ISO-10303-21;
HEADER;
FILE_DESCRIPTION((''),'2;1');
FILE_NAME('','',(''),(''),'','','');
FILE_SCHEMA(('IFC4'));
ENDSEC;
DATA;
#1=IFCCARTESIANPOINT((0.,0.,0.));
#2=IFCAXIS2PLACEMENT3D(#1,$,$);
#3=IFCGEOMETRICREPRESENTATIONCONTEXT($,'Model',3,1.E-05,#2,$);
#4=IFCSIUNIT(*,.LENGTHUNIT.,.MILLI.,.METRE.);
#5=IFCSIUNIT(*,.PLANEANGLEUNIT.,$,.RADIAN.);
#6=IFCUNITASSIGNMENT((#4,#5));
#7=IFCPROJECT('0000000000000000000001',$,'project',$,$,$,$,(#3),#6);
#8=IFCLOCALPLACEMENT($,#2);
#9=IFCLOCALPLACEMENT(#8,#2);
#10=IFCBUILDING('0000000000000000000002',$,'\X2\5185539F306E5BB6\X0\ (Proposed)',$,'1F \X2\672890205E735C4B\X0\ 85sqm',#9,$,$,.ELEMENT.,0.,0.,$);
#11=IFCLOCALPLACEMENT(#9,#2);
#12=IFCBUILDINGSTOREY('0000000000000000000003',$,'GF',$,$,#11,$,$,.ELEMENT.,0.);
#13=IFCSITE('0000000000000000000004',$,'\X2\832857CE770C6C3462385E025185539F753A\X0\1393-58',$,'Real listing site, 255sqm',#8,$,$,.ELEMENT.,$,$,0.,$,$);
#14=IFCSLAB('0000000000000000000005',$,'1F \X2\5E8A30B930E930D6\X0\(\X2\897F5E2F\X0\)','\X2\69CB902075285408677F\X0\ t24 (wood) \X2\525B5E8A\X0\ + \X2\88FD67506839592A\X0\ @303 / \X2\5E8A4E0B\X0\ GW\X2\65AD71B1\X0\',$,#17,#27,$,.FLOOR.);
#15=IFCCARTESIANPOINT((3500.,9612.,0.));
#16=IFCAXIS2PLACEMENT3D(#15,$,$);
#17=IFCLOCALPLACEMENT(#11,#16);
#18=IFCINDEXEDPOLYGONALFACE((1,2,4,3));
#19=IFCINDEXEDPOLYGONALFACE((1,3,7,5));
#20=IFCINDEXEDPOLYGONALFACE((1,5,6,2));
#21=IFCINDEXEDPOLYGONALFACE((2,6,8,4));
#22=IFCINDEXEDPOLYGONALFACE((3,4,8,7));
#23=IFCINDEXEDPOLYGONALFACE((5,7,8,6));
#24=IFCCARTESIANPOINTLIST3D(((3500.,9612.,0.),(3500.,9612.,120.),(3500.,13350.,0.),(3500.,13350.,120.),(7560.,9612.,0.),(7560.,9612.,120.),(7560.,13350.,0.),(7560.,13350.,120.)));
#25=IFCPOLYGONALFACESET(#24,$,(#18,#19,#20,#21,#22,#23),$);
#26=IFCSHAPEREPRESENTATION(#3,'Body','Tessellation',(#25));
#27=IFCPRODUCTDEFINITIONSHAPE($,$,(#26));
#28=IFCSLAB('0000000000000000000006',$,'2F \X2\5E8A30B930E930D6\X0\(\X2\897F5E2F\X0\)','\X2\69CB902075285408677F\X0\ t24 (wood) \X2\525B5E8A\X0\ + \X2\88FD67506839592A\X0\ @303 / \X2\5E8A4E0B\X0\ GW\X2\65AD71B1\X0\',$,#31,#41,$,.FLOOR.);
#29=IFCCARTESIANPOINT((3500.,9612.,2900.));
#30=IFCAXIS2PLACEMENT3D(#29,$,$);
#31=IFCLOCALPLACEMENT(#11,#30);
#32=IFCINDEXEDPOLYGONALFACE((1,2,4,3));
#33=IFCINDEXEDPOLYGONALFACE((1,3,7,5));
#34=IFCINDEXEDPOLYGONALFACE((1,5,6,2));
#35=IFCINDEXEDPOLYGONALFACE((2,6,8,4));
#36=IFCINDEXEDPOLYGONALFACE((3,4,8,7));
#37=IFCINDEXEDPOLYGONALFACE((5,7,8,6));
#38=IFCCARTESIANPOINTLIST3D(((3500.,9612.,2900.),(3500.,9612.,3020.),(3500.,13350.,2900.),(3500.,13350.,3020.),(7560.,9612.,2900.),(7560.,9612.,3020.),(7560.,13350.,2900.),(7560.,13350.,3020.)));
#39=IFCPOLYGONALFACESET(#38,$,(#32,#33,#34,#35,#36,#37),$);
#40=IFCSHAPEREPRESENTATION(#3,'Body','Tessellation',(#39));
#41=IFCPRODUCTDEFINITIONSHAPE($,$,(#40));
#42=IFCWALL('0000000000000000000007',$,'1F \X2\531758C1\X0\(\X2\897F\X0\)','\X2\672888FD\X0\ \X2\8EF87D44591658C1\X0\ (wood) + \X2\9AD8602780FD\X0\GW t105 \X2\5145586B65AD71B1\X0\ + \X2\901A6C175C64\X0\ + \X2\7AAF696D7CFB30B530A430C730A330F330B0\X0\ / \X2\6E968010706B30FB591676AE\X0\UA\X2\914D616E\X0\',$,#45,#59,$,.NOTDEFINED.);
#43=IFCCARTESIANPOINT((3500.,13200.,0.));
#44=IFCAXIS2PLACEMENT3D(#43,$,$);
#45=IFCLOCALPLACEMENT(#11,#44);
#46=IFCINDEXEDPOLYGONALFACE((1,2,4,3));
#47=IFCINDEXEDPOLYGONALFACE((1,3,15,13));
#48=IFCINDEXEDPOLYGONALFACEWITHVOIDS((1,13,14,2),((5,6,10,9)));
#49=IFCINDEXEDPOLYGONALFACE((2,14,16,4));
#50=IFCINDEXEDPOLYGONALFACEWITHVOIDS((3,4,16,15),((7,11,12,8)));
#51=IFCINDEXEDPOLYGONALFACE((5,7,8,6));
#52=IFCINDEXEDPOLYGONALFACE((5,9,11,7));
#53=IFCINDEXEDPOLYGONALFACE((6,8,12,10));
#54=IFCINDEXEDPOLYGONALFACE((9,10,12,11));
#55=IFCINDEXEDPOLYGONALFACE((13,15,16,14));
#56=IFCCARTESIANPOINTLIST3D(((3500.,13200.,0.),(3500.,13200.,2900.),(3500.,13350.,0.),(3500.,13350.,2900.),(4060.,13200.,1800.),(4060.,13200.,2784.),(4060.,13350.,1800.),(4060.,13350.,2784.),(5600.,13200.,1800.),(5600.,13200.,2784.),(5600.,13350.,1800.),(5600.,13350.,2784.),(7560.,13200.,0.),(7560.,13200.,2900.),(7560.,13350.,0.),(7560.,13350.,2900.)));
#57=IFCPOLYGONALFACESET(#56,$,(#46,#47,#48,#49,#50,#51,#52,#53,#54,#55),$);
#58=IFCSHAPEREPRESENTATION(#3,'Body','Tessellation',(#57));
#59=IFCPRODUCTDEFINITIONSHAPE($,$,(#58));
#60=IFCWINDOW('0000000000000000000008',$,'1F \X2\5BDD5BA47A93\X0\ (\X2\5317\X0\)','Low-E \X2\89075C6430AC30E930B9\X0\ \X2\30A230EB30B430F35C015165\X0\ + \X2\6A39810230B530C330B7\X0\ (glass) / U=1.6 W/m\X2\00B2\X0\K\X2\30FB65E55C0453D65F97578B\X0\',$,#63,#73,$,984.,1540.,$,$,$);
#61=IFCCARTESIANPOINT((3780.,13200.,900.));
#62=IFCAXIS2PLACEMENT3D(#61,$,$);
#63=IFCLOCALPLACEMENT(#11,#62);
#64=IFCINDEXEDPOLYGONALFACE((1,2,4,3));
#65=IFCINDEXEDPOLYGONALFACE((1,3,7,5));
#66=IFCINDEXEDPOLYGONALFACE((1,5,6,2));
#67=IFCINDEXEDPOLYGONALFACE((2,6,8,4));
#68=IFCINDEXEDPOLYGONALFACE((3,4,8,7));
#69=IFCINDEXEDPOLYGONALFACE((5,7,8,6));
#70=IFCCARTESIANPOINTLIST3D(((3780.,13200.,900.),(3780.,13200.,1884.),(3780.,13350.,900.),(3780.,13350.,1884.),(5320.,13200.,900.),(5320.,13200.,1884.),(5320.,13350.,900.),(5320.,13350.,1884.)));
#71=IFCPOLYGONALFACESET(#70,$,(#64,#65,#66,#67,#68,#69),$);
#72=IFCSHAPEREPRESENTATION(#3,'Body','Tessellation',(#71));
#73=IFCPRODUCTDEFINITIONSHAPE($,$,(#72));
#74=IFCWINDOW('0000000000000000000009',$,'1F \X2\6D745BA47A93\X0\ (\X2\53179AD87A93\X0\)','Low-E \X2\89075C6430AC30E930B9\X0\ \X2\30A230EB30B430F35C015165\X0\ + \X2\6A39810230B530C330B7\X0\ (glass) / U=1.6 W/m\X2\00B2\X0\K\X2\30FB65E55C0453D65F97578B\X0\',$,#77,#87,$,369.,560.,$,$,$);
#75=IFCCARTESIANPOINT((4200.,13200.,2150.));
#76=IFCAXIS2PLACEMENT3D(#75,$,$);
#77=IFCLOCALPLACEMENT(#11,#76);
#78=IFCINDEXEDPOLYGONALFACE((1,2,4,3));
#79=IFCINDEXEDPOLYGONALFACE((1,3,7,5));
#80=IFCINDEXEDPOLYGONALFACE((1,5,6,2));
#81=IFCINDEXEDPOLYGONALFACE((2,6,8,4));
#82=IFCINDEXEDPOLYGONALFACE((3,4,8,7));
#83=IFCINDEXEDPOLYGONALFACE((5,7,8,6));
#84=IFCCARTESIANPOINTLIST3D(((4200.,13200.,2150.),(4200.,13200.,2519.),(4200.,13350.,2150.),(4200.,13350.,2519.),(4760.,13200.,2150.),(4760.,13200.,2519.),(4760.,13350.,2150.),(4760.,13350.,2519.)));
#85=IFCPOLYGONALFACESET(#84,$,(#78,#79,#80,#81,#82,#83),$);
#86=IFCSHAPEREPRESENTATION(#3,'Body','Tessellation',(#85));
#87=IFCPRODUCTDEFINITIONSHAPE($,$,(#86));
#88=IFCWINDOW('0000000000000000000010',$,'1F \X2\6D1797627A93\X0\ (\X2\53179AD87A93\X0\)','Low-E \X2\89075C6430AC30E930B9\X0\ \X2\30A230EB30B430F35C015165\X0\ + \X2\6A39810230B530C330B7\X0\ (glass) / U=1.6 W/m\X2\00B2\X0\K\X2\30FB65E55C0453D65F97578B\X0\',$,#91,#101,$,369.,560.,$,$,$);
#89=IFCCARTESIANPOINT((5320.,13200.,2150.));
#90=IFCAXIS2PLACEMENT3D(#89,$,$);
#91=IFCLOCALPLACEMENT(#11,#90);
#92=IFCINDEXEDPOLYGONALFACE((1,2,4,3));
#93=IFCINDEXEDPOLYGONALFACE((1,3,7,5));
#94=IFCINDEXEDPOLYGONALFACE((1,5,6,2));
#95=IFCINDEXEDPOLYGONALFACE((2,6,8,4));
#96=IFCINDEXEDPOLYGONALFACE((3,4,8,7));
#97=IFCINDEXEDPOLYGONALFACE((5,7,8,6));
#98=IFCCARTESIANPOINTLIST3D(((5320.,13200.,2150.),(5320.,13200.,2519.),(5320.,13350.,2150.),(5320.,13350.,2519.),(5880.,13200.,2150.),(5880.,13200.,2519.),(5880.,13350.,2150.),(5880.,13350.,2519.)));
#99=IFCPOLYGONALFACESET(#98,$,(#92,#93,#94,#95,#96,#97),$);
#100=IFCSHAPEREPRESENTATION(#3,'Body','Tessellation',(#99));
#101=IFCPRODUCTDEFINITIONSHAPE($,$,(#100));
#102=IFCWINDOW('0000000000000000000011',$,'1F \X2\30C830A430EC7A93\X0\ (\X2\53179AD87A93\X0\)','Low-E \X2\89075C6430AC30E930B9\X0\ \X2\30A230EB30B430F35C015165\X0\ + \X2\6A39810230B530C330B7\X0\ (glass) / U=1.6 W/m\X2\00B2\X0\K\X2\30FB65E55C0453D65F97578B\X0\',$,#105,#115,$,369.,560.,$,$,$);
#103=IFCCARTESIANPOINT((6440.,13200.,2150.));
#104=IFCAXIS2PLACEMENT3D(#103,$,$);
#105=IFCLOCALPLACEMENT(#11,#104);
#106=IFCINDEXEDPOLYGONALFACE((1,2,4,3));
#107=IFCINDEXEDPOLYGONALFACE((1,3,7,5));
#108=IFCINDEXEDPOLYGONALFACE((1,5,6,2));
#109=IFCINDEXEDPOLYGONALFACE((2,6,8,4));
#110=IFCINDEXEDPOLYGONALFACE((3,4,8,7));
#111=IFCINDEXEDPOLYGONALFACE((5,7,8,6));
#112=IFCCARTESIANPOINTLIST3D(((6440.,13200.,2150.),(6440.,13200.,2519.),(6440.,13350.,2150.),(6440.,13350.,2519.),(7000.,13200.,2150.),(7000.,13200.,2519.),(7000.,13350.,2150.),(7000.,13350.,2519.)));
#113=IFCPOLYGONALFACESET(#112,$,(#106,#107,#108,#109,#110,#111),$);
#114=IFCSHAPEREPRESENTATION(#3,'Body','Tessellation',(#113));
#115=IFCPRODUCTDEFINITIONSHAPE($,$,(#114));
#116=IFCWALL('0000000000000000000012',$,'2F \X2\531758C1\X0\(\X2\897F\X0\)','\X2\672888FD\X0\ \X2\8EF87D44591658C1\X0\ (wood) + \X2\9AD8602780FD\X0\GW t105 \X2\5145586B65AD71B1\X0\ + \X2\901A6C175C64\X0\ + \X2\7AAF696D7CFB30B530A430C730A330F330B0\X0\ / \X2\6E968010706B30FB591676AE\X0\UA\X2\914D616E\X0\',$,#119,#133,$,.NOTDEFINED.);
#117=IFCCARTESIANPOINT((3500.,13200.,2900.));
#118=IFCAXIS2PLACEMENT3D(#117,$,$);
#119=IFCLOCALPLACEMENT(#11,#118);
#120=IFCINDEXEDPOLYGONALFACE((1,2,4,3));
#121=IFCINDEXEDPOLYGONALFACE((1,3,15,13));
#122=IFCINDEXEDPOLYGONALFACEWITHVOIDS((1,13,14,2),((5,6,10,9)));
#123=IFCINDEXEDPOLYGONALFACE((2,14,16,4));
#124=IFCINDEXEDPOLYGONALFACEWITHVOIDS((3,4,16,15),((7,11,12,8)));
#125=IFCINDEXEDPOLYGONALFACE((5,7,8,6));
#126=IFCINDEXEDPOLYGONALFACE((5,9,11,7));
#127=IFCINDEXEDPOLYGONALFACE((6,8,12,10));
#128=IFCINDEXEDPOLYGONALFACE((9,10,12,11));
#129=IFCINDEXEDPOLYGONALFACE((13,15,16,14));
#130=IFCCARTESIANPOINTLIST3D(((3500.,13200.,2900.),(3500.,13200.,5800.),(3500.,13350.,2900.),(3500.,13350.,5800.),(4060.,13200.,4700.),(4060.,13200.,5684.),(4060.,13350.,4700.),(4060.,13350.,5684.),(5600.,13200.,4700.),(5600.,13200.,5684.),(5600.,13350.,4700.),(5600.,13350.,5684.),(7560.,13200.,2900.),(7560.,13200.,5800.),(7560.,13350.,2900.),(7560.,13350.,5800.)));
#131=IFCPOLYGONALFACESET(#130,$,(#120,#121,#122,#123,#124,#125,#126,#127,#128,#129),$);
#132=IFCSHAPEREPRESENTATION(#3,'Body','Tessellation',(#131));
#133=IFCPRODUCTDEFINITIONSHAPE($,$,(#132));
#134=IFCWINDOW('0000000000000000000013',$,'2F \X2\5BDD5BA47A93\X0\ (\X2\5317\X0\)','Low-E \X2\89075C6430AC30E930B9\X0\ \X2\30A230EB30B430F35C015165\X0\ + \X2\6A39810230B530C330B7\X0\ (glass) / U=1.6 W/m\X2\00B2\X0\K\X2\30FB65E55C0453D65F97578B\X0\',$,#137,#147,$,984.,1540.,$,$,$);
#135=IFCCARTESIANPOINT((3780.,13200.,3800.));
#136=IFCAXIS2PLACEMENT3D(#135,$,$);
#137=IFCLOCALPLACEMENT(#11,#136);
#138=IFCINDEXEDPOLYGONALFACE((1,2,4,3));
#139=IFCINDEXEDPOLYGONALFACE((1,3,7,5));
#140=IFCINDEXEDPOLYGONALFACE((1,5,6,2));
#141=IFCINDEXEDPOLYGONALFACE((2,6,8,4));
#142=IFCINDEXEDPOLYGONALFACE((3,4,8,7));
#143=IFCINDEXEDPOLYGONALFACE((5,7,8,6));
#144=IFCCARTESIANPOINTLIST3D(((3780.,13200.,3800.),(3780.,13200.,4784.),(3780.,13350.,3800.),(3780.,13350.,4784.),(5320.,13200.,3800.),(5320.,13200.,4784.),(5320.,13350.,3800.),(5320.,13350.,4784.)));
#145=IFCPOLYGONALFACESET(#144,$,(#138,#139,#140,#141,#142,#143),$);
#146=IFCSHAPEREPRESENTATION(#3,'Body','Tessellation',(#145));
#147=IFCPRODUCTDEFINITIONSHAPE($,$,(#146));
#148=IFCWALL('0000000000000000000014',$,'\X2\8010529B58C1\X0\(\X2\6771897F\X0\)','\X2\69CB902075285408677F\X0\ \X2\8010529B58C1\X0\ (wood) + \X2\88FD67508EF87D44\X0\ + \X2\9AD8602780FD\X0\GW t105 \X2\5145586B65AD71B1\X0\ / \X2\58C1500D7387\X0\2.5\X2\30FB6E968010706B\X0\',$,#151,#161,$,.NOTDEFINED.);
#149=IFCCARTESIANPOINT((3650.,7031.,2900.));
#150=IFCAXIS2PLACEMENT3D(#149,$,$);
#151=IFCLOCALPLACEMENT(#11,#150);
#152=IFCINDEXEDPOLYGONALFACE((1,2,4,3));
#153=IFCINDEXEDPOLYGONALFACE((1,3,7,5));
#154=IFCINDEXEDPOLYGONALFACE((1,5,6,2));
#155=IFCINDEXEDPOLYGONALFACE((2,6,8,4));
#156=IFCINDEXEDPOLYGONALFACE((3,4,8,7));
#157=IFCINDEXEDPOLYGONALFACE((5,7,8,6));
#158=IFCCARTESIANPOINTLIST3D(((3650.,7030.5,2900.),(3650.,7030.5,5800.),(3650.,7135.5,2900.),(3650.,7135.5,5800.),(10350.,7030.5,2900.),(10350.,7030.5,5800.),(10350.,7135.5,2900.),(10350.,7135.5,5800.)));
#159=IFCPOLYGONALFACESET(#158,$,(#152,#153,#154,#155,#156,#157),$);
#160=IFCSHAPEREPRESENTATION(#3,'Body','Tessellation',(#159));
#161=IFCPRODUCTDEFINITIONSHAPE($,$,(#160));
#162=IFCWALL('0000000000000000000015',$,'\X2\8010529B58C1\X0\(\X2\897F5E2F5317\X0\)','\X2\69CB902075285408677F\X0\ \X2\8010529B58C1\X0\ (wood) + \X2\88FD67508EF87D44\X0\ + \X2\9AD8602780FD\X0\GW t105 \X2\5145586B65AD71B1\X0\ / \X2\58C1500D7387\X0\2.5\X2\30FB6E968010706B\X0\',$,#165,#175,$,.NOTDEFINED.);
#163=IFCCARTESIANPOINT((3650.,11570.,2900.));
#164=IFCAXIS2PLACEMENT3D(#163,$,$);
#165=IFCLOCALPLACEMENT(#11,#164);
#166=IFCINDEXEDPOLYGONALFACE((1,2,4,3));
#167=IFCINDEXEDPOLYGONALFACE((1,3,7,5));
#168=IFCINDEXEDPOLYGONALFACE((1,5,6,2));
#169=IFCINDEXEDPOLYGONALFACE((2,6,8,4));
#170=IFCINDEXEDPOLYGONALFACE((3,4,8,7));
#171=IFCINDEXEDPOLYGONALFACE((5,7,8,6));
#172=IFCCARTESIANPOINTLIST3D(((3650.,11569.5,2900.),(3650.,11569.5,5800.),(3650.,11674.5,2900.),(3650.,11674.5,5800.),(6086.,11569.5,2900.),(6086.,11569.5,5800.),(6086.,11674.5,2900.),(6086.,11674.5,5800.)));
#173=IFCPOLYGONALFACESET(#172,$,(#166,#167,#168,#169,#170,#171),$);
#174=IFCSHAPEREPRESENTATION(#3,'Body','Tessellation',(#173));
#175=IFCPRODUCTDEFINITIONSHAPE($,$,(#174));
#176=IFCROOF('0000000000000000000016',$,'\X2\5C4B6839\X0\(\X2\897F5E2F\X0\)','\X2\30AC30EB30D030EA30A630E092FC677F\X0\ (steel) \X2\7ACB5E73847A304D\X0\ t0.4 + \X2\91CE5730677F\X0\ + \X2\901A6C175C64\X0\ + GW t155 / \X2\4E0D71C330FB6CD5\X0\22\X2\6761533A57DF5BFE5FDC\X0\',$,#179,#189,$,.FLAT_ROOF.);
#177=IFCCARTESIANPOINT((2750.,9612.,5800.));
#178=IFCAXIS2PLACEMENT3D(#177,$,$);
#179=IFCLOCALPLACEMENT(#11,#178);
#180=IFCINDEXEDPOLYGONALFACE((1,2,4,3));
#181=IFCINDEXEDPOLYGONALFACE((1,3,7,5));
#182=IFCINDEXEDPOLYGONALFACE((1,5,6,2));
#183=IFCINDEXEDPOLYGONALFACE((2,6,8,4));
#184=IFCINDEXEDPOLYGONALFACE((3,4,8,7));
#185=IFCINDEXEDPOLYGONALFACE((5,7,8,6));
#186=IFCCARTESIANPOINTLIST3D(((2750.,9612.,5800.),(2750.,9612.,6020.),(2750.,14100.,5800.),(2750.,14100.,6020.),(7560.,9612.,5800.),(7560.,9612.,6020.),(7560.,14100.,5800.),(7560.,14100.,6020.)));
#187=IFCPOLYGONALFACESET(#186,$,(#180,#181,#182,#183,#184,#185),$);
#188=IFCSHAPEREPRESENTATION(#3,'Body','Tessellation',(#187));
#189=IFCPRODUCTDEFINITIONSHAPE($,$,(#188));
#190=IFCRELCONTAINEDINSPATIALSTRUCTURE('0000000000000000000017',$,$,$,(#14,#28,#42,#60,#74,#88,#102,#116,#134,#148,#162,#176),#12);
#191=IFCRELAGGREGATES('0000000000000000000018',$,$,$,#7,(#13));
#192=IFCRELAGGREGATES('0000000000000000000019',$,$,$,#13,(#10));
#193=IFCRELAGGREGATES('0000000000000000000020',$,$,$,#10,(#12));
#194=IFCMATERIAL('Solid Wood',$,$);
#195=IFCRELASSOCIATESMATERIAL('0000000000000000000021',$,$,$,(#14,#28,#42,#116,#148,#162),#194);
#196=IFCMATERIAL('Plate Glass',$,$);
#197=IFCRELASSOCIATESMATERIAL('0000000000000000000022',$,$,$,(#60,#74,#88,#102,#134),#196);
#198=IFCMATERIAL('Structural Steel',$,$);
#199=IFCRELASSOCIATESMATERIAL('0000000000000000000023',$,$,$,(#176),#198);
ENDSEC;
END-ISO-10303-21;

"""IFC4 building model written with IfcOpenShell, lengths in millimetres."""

from ifc_helpers import new_model, si_unit, frame, frame_2d, origin, place, context, project, spatial, rectangle, extrude, material, element, fill, save


model = new_model("IFC4")

# Units and contexts
model_context = context("Model", 3, precision=1e-05, world=origin())
ifc_project = project(units=[si_unit("LENGTHUNIT", "METRE", prefix="MILLI"), si_unit("PLANEANGLEUNIT", "RADIAN")], contexts=[model_context])

# Site, building, storey
site_placement = place(None, origin())
site = spatial("IfcSite", under=ifc_project, at=site_placement, Name="茨城県水戸市内原町1393-58", ObjectType="Real listing site, 255sqm", CompositionType="ELEMENT", RefElevation=0.0)
building_placement = place(site_placement, origin())
building = spatial("IfcBuilding", under=site, at=building_placement, Name="内原の家 (Proposed)", ObjectType="1F 木造平屋 85sqm", CompositionType="ELEMENT", ElevationOfRefHeight=0.0, ElevationOfTerrain=0.0)
storey_placement = place(building_placement, origin())
storey = spatial("IfcBuildingStorey", under=building, at=storey_placement, Name="GF", CompositionType="ELEMENT", Elevation=0.0)

# Slabs
ifc_material_1 = material(Name="Solid Wood")
slab_1_placement = place(storey_placement, frame((3500.0, 9612.0, 0.0)))
element("IfcSlab", 1, at=slab_1_placement, inside=storey, material=ifc_material_1, Name="1F 床スラブ(西帯)", Description="構造用合板 t24 (wood) 剛床 + 製材根太 @303 / 床下 GW断熱", PredefinedType="FLOOR", context=model_context, shape_type="SweptSolid", body=[
    extrude(rectangle(XDim=4060.0, YDim=3738.0, at=frame_2d((2030.0, 1869.0))), frame((3500.0, 9612.0, 0.0)), (0.0, 0.0, 1.0), 120.0),
])
slab_2_placement = place(storey_placement, frame((3500.0, 9612.0, 2900.0)))
element("IfcSlab", 2, at=slab_2_placement, inside=storey, material=ifc_material_1, Name="2F 床スラブ(西帯)", Description="構造用合板 t24 (wood) 剛床 + 製材根太 @303 / 床下 GW断熱", PredefinedType="FLOOR", context=model_context, shape_type="SweptSolid", body=[
    extrude(rectangle(XDim=4060.0, YDim=3738.0, at=frame_2d((2030.0, 1869.0))), frame((3500.0, 9612.0, 2900.0)), (0.0, 0.0, 1.0), 120.0),
])

# Wall, openings, windows
wall_1_placement = place(storey_placement, frame((3500.0, 13200.0, 0.0)))
wall_1 = element("IfcWall", 3, at=wall_1_placement, inside=storey, material=ifc_material_1, Name="1F 北壁(西)", Description="木製 軸組外壁 (wood) + 高性能GW t105 充填断熱 + 通気層 + 窯業系サイディング / 準耐火・外皮UA配慮", PredefinedType="NOTDEFINED", context=model_context, shape_type="SweptSolid", body=[
    extrude(rectangle(XDim=4060.0, YDim=150.0, at=frame_2d((2030.0, 75.0))), frame((3500.0, 13200.0, 0.0)), (0.0, 0.0, 1.0), 2900.0),
])
opening_1_placement = place(storey_placement, frame((3780.0, 13200.0, 900.0)))
opening_1 = element("IfcOpeningElement", 4, at=opening_1_placement, cuts=wall_1, PredefinedType="NOTDEFINED", context=model_context, shape_type="SweptSolid", body=[
    extrude(rectangle(XDim=1540.0, YDim=150.0, at=frame_2d((770.0, 75.0))), frame((3780.0, 13200.0, 900.0)), (0.0, 0.0, 1.0), 984.0),
])
opening_2_placement = place(storey_placement, frame((4200.0, 13200.0, 2150.0)))
opening_2 = element("IfcOpeningElement", 5, at=opening_2_placement, cuts=wall_1, PredefinedType="NOTDEFINED", context=model_context, shape_type="SweptSolid", body=[
    extrude(rectangle(XDim=560.0, YDim=150.0, at=frame_2d((280.0, 75.0))), frame((4200.0, 13200.0, 2150.0)), (0.0, 0.0, 1.0), 369.0),
])
opening_3_placement = place(storey_placement, frame((5320.0, 13200.0, 2150.0)))
opening_3 = element("IfcOpeningElement", 6, at=opening_3_placement, cuts=wall_1, PredefinedType="NOTDEFINED", context=model_context, shape_type="SweptSolid", body=[
    extrude(rectangle(XDim=560.0, YDim=150.0, at=frame_2d((280.0, 75.0))), frame((5320.0, 13200.0, 2150.0)), (0.0, 0.0, 1.0), 369.0),
])
opening_4_placement = place(storey_placement, frame((6440.0, 13200.0, 2150.0)))
opening_4 = element("IfcOpeningElement", 7, at=opening_4_placement, cuts=wall_1, PredefinedType="NOTDEFINED", context=model_context, shape_type="SweptSolid", body=[
    extrude(rectangle(XDim=560.0, YDim=150.0, at=frame_2d((280.0, 75.0))), frame((6440.0, 13200.0, 2150.0)), (0.0, 0.0, 1.0), 369.0),
])
ifc_material_2 = material(Name="Plate Glass")
window_1_placement = place(storey_placement, frame((3780.0, 13200.0, 900.0)))
window_1 = element("IfcWindow", 8, at=window_1_placement, inside=storey, material=ifc_material_2, Name="1F 寝室窓 (北)", Description="Low-E 複層ガラス アルゴン封入 + 樹脂サッシ (glass) / U=1.6 W/m²K・日射取得型", OverallHeight=984.0, OverallWidth=1540.0, context=model_context, shape_type="SweptSolid", body=[
    extrude(rectangle(XDim=1540.0, YDim=150.0, at=frame_2d((770.0, 75.0))), frame((3780.0, 13200.0, 900.0)), (0.0, 0.0, 1.0), 984.0),
])
fill(opening_1, window_1)
window_2_placement = place(storey_placement, frame((4200.0, 13200.0, 2150.0)))
window_2 = element("IfcWindow", 9, at=window_2_placement, inside=storey, material=ifc_material_2, Name="1F 浴室窓 (北高窓)", Description="Low-E 複層ガラス アルゴン封入 + 樹脂サッシ (glass) / U=1.6 W/m²K・日射取得型", OverallHeight=369.0, OverallWidth=560.0, context=model_context, shape_type="SweptSolid", body=[
    extrude(rectangle(XDim=560.0, YDim=150.0, at=frame_2d((280.0, 75.0))), frame((4200.0, 13200.0, 2150.0)), (0.0, 0.0, 1.0), 369.0),
])
fill(opening_2, window_2)
window_3_placement = place(storey_placement, frame((5320.0, 13200.0, 2150.0)))
window_3 = element("IfcWindow", 10, at=window_3_placement, inside=storey, material=ifc_material_2, Name="1F 洗面窓 (北高窓)", Description="Low-E 複層ガラス アルゴン封入 + 樹脂サッシ (glass) / U=1.6 W/m²K・日射取得型", OverallHeight=369.0, OverallWidth=560.0, context=model_context, shape_type="SweptSolid", body=[
    extrude(rectangle(XDim=560.0, YDim=150.0, at=frame_2d((280.0, 75.0))), frame((5320.0, 13200.0, 2150.0)), (0.0, 0.0, 1.0), 369.0),
])
fill(opening_3, window_3)
window_4_placement = place(storey_placement, frame((6440.0, 13200.0, 2150.0)))
window_4 = element("IfcWindow", 11, at=window_4_placement, inside=storey, material=ifc_material_2, Name="1F トイレ窓 (北高窓)", Description="Low-E 複層ガラス アルゴン封入 + 樹脂サッシ (glass) / U=1.6 W/m²K・日射取得型", OverallHeight=369.0, OverallWidth=560.0, context=model_context, shape_type="SweptSolid", body=[
    extrude(rectangle(XDim=560.0, YDim=150.0, at=frame_2d((280.0, 75.0))), frame((6440.0, 13200.0, 2150.0)), (0.0, 0.0, 1.0), 369.0),
])
fill(opening_4, window_4)

# Wall, opening, window
wall_2_placement = place(storey_placement, frame((3500.0, 13200.0, 2900.0)))
wall_2 = element("IfcWall", 12, at=wall_2_placement, inside=storey, material=ifc_material_1, Name="2F 北壁(西)", Description="木製 軸組外壁 (wood) + 高性能GW t105 充填断熱 + 通気層 + 窯業系サイディング / 準耐火・外皮UA配慮", PredefinedType="NOTDEFINED", context=model_context, shape_type="SweptSolid", body=[
    extrude(rectangle(XDim=4060.0, YDim=150.0, at=frame_2d((2030.0, 75.0))), frame((3500.0, 13200.0, 2900.0)), (0.0, 0.0, 1.0), 2900.0),
])
opening_5_placement = place(storey_placement, frame((3780.0, 13200.0, 3800.0)))
opening_5 = element("IfcOpeningElement", 13, at=opening_5_placement, cuts=wall_2, PredefinedType="NOTDEFINED", context=model_context, shape_type="SweptSolid", body=[
    extrude(rectangle(XDim=1540.0, YDim=150.0, at=frame_2d((770.0, 75.0))), frame((3780.0, 13200.0, 3800.0)), (0.0, 0.0, 1.0), 984.0),
])
window_5_placement = place(storey_placement, frame((3780.0, 13200.0, 3800.0)))
window_5 = element("IfcWindow", 14, at=window_5_placement, inside=storey, material=ifc_material_2, Name="2F 寝室窓 (北)", Description="Low-E 複層ガラス アルゴン封入 + 樹脂サッシ (glass) / U=1.6 W/m²K・日射取得型", OverallHeight=984.0, OverallWidth=1540.0, context=model_context, shape_type="SweptSolid", body=[
    extrude(rectangle(XDim=1540.0, YDim=150.0, at=frame_2d((770.0, 75.0))), frame((3780.0, 13200.0, 3800.0)), (0.0, 0.0, 1.0), 984.0),
])
fill(opening_5, window_5)

# Walls
wall_3_placement = place(storey_placement, frame((3650.0, 7031.0, 2900.0)))
element("IfcWall", 15, at=wall_3_placement, inside=storey, material=ifc_material_1, Name="耐力壁(東西)", Description="構造用合板 耐力壁 (wood) + 製材軸組 + 高性能GW t105 充填断熱 / 壁倍率2.5・準耐火", PredefinedType="NOTDEFINED", context=model_context, shape_type="SweptSolid", body=[
    extrude(rectangle(XDim=6700.0, YDim=105.0, at=frame_2d((3350.0, 52.0))), frame((3650.0, 7031.0, 2900.0)), (0.0, 0.0, 1.0), 2900.0),
])
wall_4_placement = place(storey_placement, frame((3650.0, 11570.0, 2900.0)))
element("IfcWall", 16, at=wall_4_placement, inside=storey, material=ifc_material_1, Name="耐力壁(西帯北)", Description="構造用合板 耐力壁 (wood) + 製材軸組 + 高性能GW t105 充填断熱 / 壁倍率2.5・準耐火", PredefinedType="NOTDEFINED", context=model_context, shape_type="SweptSolid", body=[
    extrude(rectangle(XDim=2436.0, YDim=105.0, at=frame_2d((1218.0, 52.0))), frame((3650.0, 11570.0, 2900.0)), (0.0, 0.0, 1.0), 2900.0),
])

# Roof
ifc_material_3 = material(Name="Structural Steel")
for number, where, name in (
    (17, (2750.0, 9612.0, 5800.0), "屋根(西帯)"),
):
    element("IfcRoof", number, at=place(storey_placement, frame(where)), inside=storey, material=ifc_material_3, Name=name, Description="ガルバリウム鋼板 (steel) 立平葺き t0.4 + 野地板 + 通気層 + GW t155 / 不燃・法22条区域対応", PredefinedType="FLAT_ROOF", context=model_context, shape_type="SweptSolid", body=[
        extrude(rectangle(XDim=4810.0, YDim=4488.0, at=frame_2d((2405.0, 2244.0))), frame((2750.0, 9612.0, 5800.0)), (0.0, 0.0, 1.0), 220.0),
    ])

save(model, "model.ifc")
